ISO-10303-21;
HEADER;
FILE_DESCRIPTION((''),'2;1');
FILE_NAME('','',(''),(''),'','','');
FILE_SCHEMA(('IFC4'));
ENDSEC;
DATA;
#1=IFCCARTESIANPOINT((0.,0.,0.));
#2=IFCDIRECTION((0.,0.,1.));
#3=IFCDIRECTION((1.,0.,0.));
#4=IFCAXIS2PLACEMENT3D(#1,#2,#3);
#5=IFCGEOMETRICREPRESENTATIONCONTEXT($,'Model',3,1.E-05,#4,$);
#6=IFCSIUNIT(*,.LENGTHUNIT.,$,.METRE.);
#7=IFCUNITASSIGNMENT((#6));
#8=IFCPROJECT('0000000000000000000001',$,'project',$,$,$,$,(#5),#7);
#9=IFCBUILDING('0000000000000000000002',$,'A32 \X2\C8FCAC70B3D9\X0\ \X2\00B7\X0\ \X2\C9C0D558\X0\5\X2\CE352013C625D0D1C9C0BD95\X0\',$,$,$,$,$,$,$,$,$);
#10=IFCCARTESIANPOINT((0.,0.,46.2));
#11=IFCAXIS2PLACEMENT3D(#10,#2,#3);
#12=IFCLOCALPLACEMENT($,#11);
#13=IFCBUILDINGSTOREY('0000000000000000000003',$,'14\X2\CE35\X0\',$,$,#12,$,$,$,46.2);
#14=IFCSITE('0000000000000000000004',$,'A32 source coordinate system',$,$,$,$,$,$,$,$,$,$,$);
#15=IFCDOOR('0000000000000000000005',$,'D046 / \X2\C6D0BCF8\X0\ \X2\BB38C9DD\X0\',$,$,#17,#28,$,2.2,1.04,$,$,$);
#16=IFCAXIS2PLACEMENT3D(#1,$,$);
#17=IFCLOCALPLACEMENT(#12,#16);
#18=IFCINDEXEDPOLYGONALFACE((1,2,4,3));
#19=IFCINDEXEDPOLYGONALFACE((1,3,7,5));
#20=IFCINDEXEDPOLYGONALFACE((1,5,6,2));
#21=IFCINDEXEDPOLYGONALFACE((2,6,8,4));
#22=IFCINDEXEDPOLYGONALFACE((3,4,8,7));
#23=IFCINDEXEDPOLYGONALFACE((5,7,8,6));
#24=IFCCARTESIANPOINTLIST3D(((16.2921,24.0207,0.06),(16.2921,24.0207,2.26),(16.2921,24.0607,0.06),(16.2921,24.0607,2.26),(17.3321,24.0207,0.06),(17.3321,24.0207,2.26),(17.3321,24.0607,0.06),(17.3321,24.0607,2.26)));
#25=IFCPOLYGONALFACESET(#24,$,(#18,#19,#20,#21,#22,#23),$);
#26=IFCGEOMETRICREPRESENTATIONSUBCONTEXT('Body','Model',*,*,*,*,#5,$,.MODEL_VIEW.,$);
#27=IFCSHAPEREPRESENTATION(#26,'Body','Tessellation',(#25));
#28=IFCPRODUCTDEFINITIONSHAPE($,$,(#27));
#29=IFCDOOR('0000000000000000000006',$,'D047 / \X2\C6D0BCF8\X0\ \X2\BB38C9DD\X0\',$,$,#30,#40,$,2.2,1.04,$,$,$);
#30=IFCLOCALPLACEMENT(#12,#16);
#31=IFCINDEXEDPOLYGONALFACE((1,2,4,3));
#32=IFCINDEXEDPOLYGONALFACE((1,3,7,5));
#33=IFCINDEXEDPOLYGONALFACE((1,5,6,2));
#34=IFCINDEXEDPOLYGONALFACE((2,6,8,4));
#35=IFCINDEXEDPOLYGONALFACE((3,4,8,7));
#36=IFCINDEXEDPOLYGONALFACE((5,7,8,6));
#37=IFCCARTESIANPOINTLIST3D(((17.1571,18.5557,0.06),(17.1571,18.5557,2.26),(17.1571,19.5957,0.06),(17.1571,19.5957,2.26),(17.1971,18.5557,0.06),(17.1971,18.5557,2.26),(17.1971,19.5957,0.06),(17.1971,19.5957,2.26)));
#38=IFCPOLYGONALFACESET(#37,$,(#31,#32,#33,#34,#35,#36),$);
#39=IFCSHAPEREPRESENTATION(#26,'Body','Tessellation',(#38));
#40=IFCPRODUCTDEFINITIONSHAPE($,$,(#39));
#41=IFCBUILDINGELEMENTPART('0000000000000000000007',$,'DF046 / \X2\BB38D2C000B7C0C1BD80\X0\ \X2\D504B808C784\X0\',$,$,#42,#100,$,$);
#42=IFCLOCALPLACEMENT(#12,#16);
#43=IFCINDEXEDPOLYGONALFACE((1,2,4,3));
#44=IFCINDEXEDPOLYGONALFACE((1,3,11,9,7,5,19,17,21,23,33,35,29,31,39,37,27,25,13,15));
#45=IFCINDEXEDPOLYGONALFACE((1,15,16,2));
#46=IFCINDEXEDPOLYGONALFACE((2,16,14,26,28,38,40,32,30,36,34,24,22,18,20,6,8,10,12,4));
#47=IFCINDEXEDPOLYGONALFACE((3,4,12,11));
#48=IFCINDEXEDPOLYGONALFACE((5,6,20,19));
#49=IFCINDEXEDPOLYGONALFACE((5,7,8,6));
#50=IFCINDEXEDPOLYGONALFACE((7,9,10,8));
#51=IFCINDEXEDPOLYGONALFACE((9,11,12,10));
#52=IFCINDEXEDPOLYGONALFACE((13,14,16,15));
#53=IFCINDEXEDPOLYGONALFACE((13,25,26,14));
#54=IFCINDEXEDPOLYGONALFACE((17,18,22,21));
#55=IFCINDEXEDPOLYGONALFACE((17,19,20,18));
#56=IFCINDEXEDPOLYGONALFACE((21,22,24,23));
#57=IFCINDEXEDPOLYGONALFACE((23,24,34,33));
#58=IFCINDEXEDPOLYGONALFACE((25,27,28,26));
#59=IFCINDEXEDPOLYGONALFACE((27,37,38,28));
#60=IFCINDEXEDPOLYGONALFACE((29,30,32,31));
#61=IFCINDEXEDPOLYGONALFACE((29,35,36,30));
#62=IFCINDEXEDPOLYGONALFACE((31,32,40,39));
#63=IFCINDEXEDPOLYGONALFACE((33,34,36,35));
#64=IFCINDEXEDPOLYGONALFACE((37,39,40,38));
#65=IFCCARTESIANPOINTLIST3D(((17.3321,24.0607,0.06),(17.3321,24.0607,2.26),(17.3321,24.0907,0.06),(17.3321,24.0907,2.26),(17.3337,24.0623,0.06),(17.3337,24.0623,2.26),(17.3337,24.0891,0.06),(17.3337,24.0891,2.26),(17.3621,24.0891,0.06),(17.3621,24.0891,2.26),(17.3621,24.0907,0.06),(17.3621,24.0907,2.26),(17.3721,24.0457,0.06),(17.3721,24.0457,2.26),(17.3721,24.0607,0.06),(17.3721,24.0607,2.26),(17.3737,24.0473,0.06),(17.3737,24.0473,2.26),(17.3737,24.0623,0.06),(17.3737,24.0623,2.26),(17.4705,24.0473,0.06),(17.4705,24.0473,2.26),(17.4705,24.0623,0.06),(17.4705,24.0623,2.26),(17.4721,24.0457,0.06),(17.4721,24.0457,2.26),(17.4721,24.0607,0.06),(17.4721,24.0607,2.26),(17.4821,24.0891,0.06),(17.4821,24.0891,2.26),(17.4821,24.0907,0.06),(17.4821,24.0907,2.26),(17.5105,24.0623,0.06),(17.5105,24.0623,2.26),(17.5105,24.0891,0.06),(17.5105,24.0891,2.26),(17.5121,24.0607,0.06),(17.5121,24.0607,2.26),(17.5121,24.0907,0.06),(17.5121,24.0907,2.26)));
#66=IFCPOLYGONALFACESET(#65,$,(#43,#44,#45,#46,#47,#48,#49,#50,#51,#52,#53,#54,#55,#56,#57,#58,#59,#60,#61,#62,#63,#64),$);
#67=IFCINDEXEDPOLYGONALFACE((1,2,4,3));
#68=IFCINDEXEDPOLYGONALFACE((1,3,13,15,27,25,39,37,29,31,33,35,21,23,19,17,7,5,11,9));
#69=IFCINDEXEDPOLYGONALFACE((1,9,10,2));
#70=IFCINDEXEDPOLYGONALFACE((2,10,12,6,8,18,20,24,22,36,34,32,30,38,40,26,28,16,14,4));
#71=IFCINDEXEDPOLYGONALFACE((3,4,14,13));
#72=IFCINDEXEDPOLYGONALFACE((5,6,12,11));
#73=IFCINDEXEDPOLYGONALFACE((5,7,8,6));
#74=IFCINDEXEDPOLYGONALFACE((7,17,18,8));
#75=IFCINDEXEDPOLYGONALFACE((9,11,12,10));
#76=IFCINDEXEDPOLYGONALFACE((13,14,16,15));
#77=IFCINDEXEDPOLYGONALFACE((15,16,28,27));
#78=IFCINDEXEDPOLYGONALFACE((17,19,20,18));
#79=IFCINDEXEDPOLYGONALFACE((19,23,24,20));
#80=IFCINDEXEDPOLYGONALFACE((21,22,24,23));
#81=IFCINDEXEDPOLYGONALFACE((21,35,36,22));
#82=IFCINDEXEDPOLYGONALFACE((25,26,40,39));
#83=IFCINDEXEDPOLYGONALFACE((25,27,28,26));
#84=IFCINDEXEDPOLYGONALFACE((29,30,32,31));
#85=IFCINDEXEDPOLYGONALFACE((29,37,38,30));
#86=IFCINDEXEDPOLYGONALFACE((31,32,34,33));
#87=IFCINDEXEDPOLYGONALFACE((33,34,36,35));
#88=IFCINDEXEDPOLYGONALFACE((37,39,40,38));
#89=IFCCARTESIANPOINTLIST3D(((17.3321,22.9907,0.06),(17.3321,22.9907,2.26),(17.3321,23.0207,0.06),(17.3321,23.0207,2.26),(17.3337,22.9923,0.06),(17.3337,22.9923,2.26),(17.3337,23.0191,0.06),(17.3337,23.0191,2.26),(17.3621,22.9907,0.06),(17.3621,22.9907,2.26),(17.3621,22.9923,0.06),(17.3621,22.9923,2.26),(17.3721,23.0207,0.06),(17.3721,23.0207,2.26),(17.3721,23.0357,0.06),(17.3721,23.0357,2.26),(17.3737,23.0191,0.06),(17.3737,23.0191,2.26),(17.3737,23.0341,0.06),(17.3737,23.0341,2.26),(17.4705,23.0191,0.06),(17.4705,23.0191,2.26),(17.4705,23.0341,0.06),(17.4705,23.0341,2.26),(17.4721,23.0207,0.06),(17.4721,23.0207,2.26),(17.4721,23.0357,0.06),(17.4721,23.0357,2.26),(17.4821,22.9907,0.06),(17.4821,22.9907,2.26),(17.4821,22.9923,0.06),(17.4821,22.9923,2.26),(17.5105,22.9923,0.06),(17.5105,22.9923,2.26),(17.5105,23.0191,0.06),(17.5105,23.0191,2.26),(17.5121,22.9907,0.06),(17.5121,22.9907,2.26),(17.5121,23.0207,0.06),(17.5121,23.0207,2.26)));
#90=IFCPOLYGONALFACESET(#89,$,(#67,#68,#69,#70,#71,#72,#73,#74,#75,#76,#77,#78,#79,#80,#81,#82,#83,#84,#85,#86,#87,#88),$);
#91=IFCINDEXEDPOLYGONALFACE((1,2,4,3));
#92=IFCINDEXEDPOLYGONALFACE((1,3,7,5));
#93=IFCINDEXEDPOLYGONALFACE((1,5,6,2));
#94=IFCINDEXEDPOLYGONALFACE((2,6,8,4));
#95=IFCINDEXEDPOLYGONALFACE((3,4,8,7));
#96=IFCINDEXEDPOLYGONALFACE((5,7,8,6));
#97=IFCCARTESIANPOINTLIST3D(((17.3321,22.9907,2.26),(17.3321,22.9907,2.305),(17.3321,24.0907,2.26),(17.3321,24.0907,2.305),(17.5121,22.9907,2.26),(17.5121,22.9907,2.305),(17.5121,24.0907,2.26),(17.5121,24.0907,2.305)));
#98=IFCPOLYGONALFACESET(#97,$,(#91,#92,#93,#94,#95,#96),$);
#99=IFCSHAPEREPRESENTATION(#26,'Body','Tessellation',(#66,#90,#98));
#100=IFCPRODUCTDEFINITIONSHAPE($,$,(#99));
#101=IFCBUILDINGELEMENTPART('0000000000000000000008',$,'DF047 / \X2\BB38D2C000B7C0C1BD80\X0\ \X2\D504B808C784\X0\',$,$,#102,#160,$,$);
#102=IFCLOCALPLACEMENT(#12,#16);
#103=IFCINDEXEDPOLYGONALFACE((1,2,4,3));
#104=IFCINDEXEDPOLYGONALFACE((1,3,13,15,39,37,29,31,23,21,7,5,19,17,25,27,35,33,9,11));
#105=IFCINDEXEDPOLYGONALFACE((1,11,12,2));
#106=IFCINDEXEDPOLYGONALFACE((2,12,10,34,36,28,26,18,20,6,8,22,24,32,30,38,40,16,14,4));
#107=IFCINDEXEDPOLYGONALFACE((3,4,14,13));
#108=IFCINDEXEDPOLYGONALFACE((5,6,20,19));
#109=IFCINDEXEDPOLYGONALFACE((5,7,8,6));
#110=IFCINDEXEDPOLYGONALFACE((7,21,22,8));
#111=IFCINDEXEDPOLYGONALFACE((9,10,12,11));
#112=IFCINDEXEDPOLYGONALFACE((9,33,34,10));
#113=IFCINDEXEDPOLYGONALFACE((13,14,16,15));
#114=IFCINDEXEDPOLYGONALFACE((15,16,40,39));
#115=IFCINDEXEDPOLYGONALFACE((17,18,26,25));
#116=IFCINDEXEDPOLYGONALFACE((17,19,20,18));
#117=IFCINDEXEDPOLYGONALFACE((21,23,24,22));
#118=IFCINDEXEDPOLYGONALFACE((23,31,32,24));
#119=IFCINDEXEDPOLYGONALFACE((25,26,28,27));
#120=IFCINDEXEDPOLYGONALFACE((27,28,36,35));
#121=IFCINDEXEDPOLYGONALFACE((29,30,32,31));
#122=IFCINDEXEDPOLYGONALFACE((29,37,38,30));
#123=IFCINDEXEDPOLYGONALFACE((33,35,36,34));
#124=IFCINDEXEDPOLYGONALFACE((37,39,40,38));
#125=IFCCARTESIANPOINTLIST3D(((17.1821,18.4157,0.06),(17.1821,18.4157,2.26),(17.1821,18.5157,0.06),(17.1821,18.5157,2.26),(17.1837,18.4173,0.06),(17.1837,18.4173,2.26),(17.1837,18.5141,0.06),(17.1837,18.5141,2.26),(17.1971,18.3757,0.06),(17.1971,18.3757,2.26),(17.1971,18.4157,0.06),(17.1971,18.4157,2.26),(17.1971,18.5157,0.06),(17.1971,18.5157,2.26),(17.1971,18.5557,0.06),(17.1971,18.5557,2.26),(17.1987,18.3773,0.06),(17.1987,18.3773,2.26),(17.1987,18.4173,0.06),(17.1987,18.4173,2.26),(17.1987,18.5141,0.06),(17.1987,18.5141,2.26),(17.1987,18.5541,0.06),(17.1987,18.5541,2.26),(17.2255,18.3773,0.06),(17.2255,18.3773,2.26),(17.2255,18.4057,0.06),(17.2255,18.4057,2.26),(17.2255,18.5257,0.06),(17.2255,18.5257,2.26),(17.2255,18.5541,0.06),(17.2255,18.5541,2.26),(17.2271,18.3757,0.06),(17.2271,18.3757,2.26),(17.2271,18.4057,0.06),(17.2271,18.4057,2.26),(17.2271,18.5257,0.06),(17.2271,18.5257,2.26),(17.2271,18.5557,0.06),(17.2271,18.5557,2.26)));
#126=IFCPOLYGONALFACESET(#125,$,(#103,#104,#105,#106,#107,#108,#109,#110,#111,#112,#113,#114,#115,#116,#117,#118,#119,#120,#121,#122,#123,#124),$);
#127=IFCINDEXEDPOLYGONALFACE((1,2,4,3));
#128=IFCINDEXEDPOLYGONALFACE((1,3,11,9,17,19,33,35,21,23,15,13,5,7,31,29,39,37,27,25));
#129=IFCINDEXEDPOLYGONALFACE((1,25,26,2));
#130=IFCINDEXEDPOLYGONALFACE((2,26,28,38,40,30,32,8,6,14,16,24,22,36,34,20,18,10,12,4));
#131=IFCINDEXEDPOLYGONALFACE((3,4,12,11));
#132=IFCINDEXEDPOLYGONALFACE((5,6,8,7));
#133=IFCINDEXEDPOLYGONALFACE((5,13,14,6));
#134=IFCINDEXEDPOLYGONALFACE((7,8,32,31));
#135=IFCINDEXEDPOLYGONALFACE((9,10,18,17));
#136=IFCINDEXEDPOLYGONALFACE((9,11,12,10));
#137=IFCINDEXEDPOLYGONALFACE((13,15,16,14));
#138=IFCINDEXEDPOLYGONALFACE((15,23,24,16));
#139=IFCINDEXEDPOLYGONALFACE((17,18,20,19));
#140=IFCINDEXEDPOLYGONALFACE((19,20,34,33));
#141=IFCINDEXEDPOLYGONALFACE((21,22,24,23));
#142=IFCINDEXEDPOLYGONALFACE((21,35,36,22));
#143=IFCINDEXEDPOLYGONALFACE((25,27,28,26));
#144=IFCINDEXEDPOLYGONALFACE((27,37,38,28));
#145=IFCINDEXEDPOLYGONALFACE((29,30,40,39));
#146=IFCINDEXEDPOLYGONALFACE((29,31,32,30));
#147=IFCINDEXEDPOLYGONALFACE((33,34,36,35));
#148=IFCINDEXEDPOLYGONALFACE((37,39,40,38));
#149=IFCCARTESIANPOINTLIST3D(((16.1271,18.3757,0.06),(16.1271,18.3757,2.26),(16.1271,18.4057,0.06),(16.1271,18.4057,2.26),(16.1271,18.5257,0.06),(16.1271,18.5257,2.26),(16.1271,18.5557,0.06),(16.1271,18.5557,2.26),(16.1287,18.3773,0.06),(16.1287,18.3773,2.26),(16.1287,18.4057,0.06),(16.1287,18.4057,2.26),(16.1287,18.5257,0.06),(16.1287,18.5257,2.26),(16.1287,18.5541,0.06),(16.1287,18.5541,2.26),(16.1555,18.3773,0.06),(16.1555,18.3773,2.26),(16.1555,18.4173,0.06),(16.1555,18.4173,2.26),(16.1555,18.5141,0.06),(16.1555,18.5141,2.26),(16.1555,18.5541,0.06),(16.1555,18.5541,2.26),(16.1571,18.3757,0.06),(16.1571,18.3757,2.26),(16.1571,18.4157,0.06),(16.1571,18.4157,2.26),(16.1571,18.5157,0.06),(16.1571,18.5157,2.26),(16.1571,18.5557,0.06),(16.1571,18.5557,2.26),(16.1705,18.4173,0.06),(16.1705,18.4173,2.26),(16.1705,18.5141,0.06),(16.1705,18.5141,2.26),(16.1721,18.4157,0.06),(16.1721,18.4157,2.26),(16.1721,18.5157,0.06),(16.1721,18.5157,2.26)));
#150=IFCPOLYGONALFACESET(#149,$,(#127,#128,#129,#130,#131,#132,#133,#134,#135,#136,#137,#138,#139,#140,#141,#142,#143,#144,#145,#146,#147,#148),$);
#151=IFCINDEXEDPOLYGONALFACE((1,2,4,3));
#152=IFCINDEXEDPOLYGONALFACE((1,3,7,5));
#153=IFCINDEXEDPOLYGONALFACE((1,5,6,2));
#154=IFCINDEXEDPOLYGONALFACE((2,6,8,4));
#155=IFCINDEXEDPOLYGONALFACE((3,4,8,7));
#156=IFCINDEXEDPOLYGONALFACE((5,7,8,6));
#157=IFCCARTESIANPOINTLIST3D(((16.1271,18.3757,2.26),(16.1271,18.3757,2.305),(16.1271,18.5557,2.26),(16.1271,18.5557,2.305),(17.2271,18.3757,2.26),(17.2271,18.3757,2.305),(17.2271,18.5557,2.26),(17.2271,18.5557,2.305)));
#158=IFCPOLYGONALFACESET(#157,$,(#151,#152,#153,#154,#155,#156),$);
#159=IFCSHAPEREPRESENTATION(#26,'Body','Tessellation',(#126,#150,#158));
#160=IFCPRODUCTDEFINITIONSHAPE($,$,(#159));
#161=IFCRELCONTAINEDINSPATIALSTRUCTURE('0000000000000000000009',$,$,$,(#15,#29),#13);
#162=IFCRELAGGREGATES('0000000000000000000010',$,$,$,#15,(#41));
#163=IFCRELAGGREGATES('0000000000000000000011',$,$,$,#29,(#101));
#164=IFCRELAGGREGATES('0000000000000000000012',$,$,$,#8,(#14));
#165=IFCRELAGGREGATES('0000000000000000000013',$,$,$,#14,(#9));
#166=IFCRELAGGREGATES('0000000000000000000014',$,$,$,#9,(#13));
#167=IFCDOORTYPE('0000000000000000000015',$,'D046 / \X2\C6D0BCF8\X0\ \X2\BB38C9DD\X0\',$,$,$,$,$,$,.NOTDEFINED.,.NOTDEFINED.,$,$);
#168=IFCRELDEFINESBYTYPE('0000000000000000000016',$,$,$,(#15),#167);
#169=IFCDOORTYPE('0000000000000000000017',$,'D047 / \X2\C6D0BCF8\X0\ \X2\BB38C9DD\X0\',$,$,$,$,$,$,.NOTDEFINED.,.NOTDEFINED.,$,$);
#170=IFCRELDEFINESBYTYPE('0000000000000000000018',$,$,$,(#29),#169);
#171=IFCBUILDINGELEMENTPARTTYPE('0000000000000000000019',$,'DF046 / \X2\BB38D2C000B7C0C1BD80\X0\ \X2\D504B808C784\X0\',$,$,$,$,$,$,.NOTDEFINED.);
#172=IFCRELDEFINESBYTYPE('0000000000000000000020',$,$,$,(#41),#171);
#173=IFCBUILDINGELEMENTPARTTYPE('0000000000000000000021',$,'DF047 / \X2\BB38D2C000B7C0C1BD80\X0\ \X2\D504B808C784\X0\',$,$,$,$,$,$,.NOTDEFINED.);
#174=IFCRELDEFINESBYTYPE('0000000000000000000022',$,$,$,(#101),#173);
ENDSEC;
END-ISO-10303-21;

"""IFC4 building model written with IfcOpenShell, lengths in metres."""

from ifc_helpers import new_model, si_unit, frame, origin, origin_with_axes, place, context, subcontext, project, spatial, polyline, outline, extrude, source, transform, mapped, type_object, type_shapes, element, aggregate, save


model = new_model("IFC4")

# Units and contexts
model_context = context("Model", 3, precision=1e-05, world=origin_with_axes())
body_context = subcontext(model_context, "Body", "Model", "MODEL_VIEW")
ifc_project = project(units=[si_unit("LENGTHUNIT", "METRE")], contexts=[model_context])

# Site, building, storey
storey_placement = place(None, frame((0.0, 0.0, 46.2), z_axis=(0.0, 0.0, 1.0), x_axis=(1.0, 0.0, 0.0)))
site = spatial("IfcSite", under=ifc_project, Name="A32 source coordinate system")
building = spatial("IfcBuilding", under=site, Name="A32 주거동 · 지하5층–옥탑지붕")
storey = spatial("IfcBuildingStorey", under=building, at=storey_placement, Name="14층", Elevation=46.2)

# Doors
door_type_1 = type_object("IfcDoorType", Name="D046 / 원본 문짝", OperationType="NOTDEFINED", PredefinedType="NOTDEFINED")
shared_shape_1 = source(origin(), body_context, "Body", "SweptSolid", [
    extrude(outline(polyline([(17.3321, 24.0607), (17.3321, 24.0207), (16.2921, 24.0207), (16.2921, 24.0607), (17.3321, 24.0607)])), frame((0.0, 0.0, 0.06)), (0.0, 0.0, 1.0), 2.2),
])
type_shapes(door_type_1, [shared_shape_1])
door_1_placement = place(storey_placement, origin_with_axes())
door_1 = element("IfcDoor", 1, at=door_1_placement, inside=storey, type_object=door_type_1, Name="D046 / 원본 문짝", OverallHeight=2.2, OverallWidth=1.04, context=body_context, shape_type="MappedRepresentation", body=[
    mapped(shared_shape_1, transform((0.0, 0.0, 0.0), scale=1.0)),
])
door_type_2 = type_object("IfcDoorType", Name="D047 / 원본 문짝", OperationType="NOTDEFINED", PredefinedType="NOTDEFINED")
shared_shape_2 = source(origin(), body_context, "Body", "SweptSolid", [
    extrude(outline(polyline([(17.1971, 18.5557), (17.1571, 18.5557), (17.1571, 19.5957), (17.1971, 19.5957), (17.1971, 18.5557)])), frame((0.0, 0.0, 0.06)), (0.0, 0.0, 1.0), 2.2),
])
type_shapes(door_type_2, [shared_shape_2])
door_2_placement = place(storey_placement, origin_with_axes())
door_2 = element("IfcDoor", 2, at=door_2_placement, inside=storey, type_object=door_type_2, Name="D047 / 원본 문짝", OverallHeight=2.2, OverallWidth=1.04, context=body_context, shape_type="MappedRepresentation", body=[
    mapped(shared_shape_2, transform((0.0, 0.0, 0.0), scale=1.0)),
])

# Building element parts
building_element_part_type_1 = type_object("IfcBuildingElementPartType", Name="DF046 / 문틀·상부 프레임", PredefinedType="NOTDEFINED")
shared_shape_3 = source(origin(), body_context, "Body", "SweptSolid", [
    extrude(outline(polyline([(17.3337, 24.0891), (17.3337, 24.0623), (17.3737, 24.0623), (17.3737, 24.0473), (17.4705, 24.0473), (17.4705, 24.0623), (17.5105, 24.0623), (17.5105, 24.0891), (17.4821, 24.0891), (17.4821, 24.0907), (17.5121, 24.0907), (17.5121, 24.0607), (17.4721, 24.0607), (17.4721, 24.0457), (17.3721, 24.0457), (17.3721, 24.0607), (17.3321, 24.0607), (17.3321, 24.0907), (17.3621, 24.0907), (17.3621, 24.0891), (17.3337, 24.0891)])), frame((0.0, 0.0, 0.06)), (0.0, 0.0, 1.0), 2.2),
    extrude(outline(polyline([(17.3621, 22.9907), (17.3321, 22.9907), (17.3321, 23.0207), (17.3721, 23.0207), (17.3721, 23.0357), (17.4721, 23.0357), (17.4721, 23.0207), (17.5121, 23.0207), (17.5121, 22.9907), (17.4821, 22.9907), (17.4821, 22.9923), (17.5105, 22.9923), (17.5105, 23.0191), (17.4705, 23.0191), (17.4705, 23.0341), (17.3737, 23.0341), (17.3737, 23.0191), (17.3337, 23.0191), (17.3337, 22.9923), (17.3621, 22.9923), (17.3621, 22.9907)])), frame((0.0, 0.0, 0.06)), (0.0, 0.0, 1.0), 2.2),
    extrude(outline(polyline([(17.3321, 22.9907), (17.3321, 24.0907), (17.5121, 24.0907), (17.5121, 22.9907), (17.3321, 22.9907)])), frame((0.0, 0.0, 2.26)), (0.0, 0.0, 1.0), 0.045),
])
type_shapes(building_element_part_type_1, [shared_shape_3])
building_element_part_1_placement = place(door_1_placement, origin_with_axes())
building_element_part_1 = element("IfcBuildingElementPart", 3, at=building_element_part_1_placement, type_object=building_element_part_type_1, Name="DF046 / 문틀·상부 프레임", context=body_context, shape_type="MappedRepresentation", body=[
    mapped(shared_shape_3, transform((0.0, 0.0, 0.0), scale=1.0)),
])
aggregate(door_1, [building_element_part_1])
building_element_part_type_2 = type_object("IfcBuildingElementPartType", Name="DF047 / 문틀·상부 프레임", PredefinedType="NOTDEFINED")
shared_shape_4 = source(origin(), body_context, "Body", "SweptSolid", [
    extrude(outline(polyline([(17.2255, 18.5541), (17.1987, 18.5541), (17.1987, 18.5141), (17.1837, 18.5141), (17.1837, 18.4173), (17.1987, 18.4173), (17.1987, 18.3773), (17.2255, 18.3773), (17.2255, 18.4057), (17.2271, 18.4057), (17.2271, 18.3757), (17.1971, 18.3757), (17.1971, 18.4157), (17.1821, 18.4157), (17.1821, 18.5157), (17.1971, 18.5157), (17.1971, 18.5557), (17.2271, 18.5557), (17.2271, 18.5257), (17.2255, 18.5257), (17.2255, 18.5541)])), frame((0.0, 0.0, 0.06)), (0.0, 0.0, 1.0), 2.2),
    extrude(outline(polyline([(16.1271, 18.5257), (16.1271, 18.5557), (16.1571, 18.5557), (16.1571, 18.5157), (16.1721, 18.5157), (16.1721, 18.4157), (16.1571, 18.4157), (16.1571, 18.3757), (16.1271, 18.3757), (16.1271, 18.4057), (16.1287, 18.4057), (16.1287, 18.3773), (16.1555, 18.3773), (16.1555, 18.4173), (16.1705, 18.4173), (16.1705, 18.5141), (16.1555, 18.5141), (16.1555, 18.5541), (16.1287, 18.5541), (16.1287, 18.5257), (16.1271, 18.5257)])), frame((0.0, 0.0, 0.06)), (0.0, 0.0, 1.0), 2.2),
    extrude(outline(polyline([(16.1271, 18.3757), (16.1271, 18.5557), (17.2271, 18.5557), (17.2271, 18.3757), (16.1271, 18.3757)])), frame((0.0, 0.0, 2.26)), (0.0, 0.0, 1.0), 0.045),
])
type_shapes(building_element_part_type_2, [shared_shape_4])
building_element_part_2_placement = place(door_2_placement, origin_with_axes())
building_element_part_2 = element("IfcBuildingElementPart", 4, at=building_element_part_2_placement, type_object=building_element_part_type_2, Name="DF047 / 문틀·상부 프레임", context=body_context, shape_type="MappedRepresentation", body=[
    mapped(shared_shape_4, transform((0.0, 0.0, 0.0), scale=1.0)),
])
aggregate(door_2, [building_element_part_2])

save(model, "model.ifc")
